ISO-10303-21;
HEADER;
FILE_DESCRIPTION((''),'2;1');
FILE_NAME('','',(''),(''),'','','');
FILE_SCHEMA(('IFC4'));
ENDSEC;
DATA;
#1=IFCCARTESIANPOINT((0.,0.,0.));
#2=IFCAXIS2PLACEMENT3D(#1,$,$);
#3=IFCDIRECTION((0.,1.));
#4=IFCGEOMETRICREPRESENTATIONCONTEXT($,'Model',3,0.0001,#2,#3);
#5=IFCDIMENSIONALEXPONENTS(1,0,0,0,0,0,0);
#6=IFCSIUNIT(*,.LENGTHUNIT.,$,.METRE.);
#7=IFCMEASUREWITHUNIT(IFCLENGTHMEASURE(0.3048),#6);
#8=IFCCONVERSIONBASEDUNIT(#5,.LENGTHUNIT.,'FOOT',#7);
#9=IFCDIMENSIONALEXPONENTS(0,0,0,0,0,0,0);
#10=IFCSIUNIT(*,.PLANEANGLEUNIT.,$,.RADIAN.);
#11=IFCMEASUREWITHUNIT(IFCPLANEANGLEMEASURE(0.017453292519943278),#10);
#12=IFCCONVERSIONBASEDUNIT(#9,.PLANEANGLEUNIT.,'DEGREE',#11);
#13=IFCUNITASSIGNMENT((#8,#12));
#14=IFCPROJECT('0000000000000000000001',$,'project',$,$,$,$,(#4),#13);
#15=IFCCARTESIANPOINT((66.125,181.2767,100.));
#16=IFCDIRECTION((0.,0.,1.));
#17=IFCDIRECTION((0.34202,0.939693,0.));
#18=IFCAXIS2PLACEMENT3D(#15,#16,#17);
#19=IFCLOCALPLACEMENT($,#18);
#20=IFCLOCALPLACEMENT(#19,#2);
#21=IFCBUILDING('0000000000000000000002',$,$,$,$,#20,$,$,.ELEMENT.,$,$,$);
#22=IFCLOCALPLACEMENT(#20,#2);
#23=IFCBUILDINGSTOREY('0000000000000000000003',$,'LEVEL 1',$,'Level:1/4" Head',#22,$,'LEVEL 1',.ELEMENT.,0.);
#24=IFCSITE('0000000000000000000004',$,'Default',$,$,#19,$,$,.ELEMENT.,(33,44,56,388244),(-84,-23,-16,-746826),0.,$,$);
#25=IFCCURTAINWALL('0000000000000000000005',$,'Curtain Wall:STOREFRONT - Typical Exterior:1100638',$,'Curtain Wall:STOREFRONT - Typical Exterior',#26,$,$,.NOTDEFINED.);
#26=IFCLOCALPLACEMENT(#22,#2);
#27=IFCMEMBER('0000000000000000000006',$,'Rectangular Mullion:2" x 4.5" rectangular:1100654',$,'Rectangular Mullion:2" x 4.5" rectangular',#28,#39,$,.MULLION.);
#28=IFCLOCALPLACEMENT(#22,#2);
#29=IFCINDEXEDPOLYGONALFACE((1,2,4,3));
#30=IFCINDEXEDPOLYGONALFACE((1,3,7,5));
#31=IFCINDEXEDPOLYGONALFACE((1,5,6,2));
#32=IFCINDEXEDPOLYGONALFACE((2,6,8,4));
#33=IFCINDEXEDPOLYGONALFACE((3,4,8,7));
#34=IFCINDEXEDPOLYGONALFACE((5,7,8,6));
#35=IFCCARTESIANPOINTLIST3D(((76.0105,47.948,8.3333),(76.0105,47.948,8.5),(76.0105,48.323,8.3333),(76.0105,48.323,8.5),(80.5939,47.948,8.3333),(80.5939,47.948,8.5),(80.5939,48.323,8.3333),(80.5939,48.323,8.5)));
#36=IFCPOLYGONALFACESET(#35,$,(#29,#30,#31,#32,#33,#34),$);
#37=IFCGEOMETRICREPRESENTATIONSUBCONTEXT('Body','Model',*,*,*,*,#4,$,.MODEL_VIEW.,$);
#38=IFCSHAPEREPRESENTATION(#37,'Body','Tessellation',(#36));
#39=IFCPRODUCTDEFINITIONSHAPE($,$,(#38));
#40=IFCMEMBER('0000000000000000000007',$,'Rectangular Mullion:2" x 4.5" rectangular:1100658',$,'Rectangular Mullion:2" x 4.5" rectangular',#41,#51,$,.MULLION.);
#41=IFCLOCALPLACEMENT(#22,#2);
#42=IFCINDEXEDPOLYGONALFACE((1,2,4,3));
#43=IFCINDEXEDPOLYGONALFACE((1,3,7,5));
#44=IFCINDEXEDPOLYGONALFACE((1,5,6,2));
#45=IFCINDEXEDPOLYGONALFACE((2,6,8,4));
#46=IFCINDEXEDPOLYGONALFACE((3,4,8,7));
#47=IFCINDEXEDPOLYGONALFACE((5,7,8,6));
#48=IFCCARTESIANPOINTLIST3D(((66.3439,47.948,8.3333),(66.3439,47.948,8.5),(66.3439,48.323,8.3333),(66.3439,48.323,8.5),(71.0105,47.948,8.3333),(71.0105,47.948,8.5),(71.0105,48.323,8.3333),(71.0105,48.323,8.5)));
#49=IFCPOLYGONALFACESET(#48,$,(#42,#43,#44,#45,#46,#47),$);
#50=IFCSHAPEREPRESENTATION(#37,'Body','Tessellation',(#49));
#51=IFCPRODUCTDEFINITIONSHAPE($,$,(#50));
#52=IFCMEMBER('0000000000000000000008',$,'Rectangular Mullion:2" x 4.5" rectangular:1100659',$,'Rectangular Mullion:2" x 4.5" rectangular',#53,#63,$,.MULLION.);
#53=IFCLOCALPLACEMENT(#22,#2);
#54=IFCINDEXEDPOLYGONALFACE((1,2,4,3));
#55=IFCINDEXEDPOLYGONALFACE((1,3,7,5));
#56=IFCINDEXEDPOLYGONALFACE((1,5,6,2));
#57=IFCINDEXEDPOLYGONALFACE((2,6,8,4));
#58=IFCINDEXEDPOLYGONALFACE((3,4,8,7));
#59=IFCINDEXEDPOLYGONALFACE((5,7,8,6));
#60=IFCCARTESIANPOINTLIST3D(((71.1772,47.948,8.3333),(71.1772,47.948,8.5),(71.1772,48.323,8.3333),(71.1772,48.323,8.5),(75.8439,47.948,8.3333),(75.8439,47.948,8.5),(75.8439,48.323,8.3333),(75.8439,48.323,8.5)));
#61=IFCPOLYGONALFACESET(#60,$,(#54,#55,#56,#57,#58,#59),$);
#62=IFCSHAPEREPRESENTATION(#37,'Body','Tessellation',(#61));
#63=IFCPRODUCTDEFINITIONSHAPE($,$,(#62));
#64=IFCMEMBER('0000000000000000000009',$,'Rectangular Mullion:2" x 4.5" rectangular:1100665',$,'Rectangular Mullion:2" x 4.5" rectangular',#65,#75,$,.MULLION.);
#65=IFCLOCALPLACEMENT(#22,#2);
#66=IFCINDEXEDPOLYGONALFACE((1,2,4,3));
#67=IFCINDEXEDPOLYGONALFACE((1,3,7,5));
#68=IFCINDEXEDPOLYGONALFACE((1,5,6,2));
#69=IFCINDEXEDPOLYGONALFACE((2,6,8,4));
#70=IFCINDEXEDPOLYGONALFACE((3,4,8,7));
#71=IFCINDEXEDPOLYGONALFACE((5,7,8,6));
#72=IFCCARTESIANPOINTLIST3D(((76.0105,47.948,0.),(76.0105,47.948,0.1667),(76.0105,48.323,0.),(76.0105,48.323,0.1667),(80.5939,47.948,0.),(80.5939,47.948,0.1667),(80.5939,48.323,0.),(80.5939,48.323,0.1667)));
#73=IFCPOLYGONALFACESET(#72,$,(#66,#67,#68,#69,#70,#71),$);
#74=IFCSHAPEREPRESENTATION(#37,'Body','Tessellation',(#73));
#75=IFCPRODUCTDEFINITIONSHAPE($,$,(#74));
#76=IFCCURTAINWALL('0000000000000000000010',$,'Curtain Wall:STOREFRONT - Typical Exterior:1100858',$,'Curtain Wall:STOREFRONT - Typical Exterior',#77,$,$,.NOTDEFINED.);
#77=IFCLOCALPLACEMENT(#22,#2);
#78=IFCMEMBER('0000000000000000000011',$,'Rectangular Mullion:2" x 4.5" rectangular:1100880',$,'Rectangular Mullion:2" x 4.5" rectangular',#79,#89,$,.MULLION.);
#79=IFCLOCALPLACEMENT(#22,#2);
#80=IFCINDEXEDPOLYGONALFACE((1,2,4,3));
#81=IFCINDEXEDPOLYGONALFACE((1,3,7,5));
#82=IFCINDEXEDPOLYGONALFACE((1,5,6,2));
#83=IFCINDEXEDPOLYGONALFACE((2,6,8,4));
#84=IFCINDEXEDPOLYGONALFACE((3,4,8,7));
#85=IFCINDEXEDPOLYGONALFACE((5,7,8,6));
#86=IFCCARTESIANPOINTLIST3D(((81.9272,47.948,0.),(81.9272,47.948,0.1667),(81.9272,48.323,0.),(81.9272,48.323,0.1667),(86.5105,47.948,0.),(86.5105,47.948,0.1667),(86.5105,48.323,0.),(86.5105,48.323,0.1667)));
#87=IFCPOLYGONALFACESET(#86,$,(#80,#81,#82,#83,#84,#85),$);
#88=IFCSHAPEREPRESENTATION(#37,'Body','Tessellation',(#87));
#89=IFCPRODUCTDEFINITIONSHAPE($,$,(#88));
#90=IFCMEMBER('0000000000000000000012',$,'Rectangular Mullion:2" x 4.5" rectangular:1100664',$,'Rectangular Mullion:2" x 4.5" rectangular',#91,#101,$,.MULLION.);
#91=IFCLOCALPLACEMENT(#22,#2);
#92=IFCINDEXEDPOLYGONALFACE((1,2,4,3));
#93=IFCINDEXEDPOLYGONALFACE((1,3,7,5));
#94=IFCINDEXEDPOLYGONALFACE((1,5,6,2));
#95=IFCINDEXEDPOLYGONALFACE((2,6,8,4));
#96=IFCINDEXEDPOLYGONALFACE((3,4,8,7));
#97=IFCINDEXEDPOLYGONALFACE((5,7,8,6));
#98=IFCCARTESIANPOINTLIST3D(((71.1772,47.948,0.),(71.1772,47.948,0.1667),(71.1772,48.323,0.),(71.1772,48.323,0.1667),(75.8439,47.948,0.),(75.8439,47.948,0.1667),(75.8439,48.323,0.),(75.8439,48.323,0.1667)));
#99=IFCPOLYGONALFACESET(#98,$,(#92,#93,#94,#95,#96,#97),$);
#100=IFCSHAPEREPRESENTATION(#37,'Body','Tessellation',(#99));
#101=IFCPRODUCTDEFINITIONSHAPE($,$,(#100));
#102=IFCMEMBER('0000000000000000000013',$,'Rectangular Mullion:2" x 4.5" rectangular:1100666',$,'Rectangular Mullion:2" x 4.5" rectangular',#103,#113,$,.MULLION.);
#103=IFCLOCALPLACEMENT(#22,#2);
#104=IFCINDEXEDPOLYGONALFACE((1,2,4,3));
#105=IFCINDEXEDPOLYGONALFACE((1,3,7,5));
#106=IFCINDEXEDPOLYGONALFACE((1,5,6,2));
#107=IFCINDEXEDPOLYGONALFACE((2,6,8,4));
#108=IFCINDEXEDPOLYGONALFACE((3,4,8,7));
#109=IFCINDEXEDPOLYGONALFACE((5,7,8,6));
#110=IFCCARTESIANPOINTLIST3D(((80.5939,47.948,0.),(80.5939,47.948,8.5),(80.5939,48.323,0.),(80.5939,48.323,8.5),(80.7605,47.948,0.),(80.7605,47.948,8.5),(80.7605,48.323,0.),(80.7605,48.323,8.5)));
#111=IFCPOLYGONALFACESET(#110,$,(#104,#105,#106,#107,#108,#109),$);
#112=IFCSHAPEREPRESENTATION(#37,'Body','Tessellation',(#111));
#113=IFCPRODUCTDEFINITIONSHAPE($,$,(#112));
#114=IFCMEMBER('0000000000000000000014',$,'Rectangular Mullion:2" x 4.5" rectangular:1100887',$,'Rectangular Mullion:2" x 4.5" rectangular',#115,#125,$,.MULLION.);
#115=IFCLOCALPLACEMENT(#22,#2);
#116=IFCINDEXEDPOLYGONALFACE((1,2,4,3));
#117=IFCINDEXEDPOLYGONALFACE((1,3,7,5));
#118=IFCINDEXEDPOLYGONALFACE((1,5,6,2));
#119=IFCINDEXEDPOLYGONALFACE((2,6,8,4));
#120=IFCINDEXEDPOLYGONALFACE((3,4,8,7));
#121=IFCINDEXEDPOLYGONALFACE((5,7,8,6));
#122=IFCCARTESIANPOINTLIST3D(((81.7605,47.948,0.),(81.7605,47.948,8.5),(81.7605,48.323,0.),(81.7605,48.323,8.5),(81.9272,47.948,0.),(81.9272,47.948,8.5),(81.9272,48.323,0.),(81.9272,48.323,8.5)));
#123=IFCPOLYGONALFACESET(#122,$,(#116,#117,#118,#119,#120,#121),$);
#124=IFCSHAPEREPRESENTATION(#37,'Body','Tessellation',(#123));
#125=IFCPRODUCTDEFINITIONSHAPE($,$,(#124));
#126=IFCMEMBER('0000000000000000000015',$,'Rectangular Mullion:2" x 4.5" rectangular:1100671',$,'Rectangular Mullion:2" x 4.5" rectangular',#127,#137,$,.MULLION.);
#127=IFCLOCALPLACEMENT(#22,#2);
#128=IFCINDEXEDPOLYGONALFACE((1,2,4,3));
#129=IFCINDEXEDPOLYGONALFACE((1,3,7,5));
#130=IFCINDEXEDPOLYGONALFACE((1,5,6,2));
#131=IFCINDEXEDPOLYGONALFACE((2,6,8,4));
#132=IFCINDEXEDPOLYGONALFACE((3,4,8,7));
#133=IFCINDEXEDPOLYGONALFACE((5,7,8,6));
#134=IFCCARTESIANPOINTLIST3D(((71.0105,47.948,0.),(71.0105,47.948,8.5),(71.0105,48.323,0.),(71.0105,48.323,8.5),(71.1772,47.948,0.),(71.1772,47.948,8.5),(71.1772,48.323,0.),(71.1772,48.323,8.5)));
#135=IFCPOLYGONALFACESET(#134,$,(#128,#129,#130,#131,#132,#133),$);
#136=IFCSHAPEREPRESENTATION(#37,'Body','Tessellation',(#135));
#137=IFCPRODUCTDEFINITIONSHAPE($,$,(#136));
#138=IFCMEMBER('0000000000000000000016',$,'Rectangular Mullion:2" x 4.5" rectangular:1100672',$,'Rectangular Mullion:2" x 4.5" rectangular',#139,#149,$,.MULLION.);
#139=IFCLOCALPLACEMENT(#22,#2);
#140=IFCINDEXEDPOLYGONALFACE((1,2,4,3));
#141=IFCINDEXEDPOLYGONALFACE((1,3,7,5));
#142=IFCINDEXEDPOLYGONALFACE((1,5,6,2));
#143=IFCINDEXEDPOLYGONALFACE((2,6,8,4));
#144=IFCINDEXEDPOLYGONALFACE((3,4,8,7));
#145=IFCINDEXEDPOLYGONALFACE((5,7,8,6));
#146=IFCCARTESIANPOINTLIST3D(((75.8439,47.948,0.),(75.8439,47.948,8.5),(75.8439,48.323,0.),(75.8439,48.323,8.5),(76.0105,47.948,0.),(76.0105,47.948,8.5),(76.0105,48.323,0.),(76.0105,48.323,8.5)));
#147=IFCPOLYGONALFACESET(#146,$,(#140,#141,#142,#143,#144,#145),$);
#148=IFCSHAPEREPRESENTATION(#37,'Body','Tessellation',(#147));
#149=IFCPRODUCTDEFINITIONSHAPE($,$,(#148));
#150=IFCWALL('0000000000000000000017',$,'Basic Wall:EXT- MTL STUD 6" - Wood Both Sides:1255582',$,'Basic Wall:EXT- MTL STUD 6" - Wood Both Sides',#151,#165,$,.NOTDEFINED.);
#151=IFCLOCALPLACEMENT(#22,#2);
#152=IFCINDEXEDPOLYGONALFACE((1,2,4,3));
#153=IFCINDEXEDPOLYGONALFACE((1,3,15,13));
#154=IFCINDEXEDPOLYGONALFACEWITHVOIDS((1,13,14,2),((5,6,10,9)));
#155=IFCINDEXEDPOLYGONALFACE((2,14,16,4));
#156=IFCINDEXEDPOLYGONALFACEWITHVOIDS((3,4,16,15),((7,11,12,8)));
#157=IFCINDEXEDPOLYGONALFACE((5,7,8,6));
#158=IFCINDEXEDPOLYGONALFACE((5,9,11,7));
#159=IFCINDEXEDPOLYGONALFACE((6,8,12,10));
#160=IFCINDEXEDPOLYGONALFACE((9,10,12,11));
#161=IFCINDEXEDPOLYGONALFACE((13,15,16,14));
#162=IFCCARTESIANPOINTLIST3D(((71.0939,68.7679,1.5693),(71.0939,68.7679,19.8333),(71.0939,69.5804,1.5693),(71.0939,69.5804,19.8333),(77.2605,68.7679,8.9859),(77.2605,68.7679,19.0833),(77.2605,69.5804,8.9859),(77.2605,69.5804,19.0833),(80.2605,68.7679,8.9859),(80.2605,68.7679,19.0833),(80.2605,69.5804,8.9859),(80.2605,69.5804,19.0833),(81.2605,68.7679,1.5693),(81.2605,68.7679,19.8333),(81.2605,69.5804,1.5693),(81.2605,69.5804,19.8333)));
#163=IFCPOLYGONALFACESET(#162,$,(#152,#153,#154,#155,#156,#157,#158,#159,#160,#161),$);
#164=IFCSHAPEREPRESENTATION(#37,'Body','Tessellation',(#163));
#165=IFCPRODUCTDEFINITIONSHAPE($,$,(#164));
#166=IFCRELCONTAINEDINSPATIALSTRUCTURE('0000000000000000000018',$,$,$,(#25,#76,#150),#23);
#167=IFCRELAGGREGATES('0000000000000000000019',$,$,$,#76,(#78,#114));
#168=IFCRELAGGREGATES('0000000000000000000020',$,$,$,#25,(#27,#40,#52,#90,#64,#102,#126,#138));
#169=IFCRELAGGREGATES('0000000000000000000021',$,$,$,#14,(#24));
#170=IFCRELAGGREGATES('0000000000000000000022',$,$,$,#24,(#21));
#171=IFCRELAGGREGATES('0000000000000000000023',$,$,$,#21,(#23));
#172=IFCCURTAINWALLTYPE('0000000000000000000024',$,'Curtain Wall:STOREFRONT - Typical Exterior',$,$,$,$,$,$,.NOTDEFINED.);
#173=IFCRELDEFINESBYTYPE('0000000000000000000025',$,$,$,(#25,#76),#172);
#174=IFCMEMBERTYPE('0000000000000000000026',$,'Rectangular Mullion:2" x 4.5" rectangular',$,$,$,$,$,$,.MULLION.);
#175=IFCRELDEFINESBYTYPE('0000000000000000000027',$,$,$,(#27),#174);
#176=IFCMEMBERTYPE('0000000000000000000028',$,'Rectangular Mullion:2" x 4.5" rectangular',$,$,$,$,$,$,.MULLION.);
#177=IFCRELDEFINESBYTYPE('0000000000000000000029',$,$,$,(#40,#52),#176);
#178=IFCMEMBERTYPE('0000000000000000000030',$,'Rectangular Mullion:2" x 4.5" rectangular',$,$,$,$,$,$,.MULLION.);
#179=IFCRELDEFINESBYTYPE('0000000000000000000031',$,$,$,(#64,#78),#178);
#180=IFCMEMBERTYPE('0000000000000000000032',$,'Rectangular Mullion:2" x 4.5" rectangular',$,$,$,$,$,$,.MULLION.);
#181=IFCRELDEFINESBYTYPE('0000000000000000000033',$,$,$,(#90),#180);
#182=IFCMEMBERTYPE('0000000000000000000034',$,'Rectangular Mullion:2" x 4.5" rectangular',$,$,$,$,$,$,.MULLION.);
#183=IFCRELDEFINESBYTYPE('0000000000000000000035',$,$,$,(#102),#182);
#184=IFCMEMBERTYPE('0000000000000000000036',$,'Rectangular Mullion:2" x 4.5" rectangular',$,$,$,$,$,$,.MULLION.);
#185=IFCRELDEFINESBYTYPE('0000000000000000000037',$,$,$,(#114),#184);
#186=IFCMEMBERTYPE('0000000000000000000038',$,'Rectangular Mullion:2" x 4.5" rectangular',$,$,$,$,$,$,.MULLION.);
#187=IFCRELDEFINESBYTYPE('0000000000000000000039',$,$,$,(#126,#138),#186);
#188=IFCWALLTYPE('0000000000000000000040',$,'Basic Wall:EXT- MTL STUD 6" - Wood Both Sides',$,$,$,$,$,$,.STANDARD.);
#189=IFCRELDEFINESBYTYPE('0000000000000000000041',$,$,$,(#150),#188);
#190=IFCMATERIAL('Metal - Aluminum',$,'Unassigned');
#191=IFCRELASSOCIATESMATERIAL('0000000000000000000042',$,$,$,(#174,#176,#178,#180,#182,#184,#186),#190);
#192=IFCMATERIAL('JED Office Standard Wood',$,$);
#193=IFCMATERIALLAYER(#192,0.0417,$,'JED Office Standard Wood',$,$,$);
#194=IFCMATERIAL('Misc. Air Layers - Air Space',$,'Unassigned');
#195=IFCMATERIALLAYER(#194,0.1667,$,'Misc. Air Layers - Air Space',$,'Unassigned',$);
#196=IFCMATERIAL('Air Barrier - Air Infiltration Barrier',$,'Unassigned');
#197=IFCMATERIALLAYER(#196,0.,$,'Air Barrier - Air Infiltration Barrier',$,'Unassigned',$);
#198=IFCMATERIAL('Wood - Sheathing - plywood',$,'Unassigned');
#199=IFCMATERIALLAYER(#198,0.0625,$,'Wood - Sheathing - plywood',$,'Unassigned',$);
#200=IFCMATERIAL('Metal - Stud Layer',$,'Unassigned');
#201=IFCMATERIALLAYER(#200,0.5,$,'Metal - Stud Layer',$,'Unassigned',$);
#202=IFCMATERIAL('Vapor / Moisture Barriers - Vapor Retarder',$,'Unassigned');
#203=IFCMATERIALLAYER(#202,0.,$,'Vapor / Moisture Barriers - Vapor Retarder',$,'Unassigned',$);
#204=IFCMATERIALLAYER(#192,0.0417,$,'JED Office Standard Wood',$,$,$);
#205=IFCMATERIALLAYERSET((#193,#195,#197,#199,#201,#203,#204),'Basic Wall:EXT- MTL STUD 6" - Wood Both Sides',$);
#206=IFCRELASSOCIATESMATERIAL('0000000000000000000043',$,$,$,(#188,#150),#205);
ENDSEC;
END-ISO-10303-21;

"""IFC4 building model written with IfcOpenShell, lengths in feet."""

from ifc_helpers import new_model, entity, si_unit, converted_unit, direction, frame, frame_2d, origin, origin_2d_with_axis, place, context, subcontext, project, spatial, rectangle, extrude, source, transform, mapped, material, layer, layer_set, layer_usage, material_profile, profile_set, type_object, type_shapes, element, aggregate, save


model = new_model("IFC4")

# Units and contexts
model_context = context("Model", 3, precision=0.0001, world=origin(), true_north=direction((0.0, 1.0)))
body_context = subcontext(model_context, "Body", "Model", "MODEL_VIEW")
ifc_project = project(units=[converted_unit("LENGTHUNIT", "FOOT", entity("IfcLengthMeasure", 0.3048), si_unit("LENGTHUNIT", "METRE"), dimensions=[1, 0, 0, 0, 0, 0, 0]), converted_unit("PLANEANGLEUNIT", "DEGREE", entity("IfcPlaneAngleMeasure", 0.017453292519943278), si_unit("PLANEANGLEUNIT", "RADIAN"), dimensions=[0, 0, 0, 0, 0, 0, 0])], contexts=[model_context])

# Site, building, storey
site_placement = place(None, frame((66.125, 181.2767, 100.0), z_axis=(0.0, 0.0, 1.0), x_axis=(0.34202, 0.939693, 0.0)))
site = spatial("IfcSite", under=ifc_project, at=site_placement, Name="Default", CompositionType="ELEMENT", RefLatitude=(33, 44, 56, 388244), RefLongitude=(-84, -23, -16, -746826), RefElevation=0.0)
building_placement = place(site_placement, origin())
building = spatial("IfcBuilding", under=site, at=building_placement, CompositionType="ELEMENT")
storey_placement = place(building_placement, origin())
storey = spatial("IfcBuildingStorey", under=building, at=storey_placement, Name="LEVEL 1", ObjectType="Level:1/4\" Head", LongName="LEVEL 1", CompositionType="ELEMENT", Elevation=0.0)

# Curtain wall, members
curtain_wall_type = type_object("IfcCurtainWallType", Name="Curtain Wall:STOREFRONT - Typical Exterior", PredefinedType="NOTDEFINED")
curtain_wall_1_placement = place(storey_placement, origin())
curtain_wall_1 = element("IfcCurtainWall", 1, at=curtain_wall_1_placement, inside=storey, type_object=curtain_wall_type, Name="Curtain Wall:STOREFRONT - Typical Exterior:1100638", ObjectType="Curtain Wall:STOREFRONT - Typical Exterior", PredefinedType="NOTDEFINED")
ifc_material_1 = material(Name="Metal - Aluminum", Category="Unassigned")
ifc_material_profile = material_profile(ifc_material_1, rectangle(XDim=0.1667, YDim=0.375, at=origin_2d_with_axis()), Name="2\" x 4.5\" rectangular")
ifc_profile_set = profile_set([ifc_material_profile], Name="2\" x 4.5\" rectangular")
member_type_1 = type_object("IfcMemberType", Name="Rectangular Mullion:2\" x 4.5\" rectangular", PredefinedType="MULLION", material=ifc_profile_set)
shared_shape_1 = source(origin(), body_context, "Body", "SweptSolid", [
    extrude(rectangle(XDim=0.1667, YDim=0.375, at=origin_2d_with_axis()), frame((-0.0833, 0.0, -4.5833), z_axis=(0.0, 0.0, 1.0), x_axis=(-1.0, 0.0, 0.0)), (0.0, 0.0, 1.0), 4.5833),
])
type_shapes(member_type_1, [shared_shape_1])
member_1_placement = place(curtain_wall_1_placement, frame((80.5939, 48.1355, 8.5), z_axis=(1.0, 0.0, 0.0), x_axis=(0.0, 0.0, 1.0)))
member_1 = element("IfcMember", 2, at=member_1_placement, type_object=member_type_1, Name="Rectangular Mullion:2\" x 4.5\" rectangular:1100654", ObjectType="Rectangular Mullion:2\" x 4.5\" rectangular", PredefinedType="MULLION", context=body_context, shape_type="MappedRepresentation", body=[
    mapped(shared_shape_1, transform((0.0, 0.0, 0.0), scale=1.0)),
])
member_type_2 = type_object("IfcMemberType", Name="Rectangular Mullion:2\" x 4.5\" rectangular", PredefinedType="MULLION", material=ifc_profile_set)
shared_shape_2 = source(origin(), body_context, "Body", "SweptSolid", [
    extrude(rectangle(XDim=0.1667, YDim=0.375, at=origin_2d_with_axis()), frame((-0.0833, 0.0, -4.6667), z_axis=(0.0, 0.0, 1.0), x_axis=(-1.0, 0.0, 0.0)), (0.0, 0.0, 1.0), 4.6667),
])
type_shapes(member_type_2, [shared_shape_2])
member_2_placement = place(curtain_wall_1_placement, frame((71.0105, 48.1355, 8.5), z_axis=(1.0, 0.0, 0.0), x_axis=(0.0, 0.0, 1.0)))
member_2 = element("IfcMember", 3, at=member_2_placement, type_object=member_type_2, Name="Rectangular Mullion:2\" x 4.5\" rectangular:1100658", ObjectType="Rectangular Mullion:2\" x 4.5\" rectangular", PredefinedType="MULLION", context=body_context, shape_type="MappedRepresentation", body=[
    mapped(shared_shape_2, transform((0.0, 0.0, 0.0), scale=1.0)),
])
member_3_placement = place(curtain_wall_1_placement, frame((75.8439, 48.1355, 8.5), z_axis=(1.0, 0.0, 0.0), x_axis=(0.0, 0.0, 1.0)))
member_3 = element("IfcMember", 4, at=member_3_placement, type_object=member_type_2, Name="Rectangular Mullion:2\" x 4.5\" rectangular:1100659", ObjectType="Rectangular Mullion:2\" x 4.5\" rectangular", PredefinedType="MULLION", context=body_context, shape_type="MappedRepresentation", body=[
    mapped(shared_shape_2, transform((0.0, 0.0, 0.0), scale=1.0)),
])
member_type_3 = type_object("IfcMemberType", Name="Rectangular Mullion:2\" x 4.5\" rectangular", PredefinedType="MULLION", material=ifc_profile_set)
shared_shape_3 = source(origin(), body_context, "Body", "SweptSolid", [
    extrude(rectangle(XDim=0.1667, YDim=0.375, at=origin_2d_with_axis()), frame((-0.0833, 0.0, -4.5833), z_axis=(0.0, 0.0, 1.0), x_axis=(-1.0, 0.0, 0.0)), (0.0, 0.0, 1.0), 4.5833),
])
type_shapes(member_type_3, [shared_shape_3])
member_4_placement = place(curtain_wall_1_placement, frame((76.0105, 48.1355, 0.0), z_axis=(-1.0, 0.0, 0.0), x_axis=(0.0, 0.0, -1.0)))
member_4 = element("IfcMember", 5, at=member_4_placement, type_object=member_type_3, Name="Rectangular Mullion:2\" x 4.5\" rectangular:1100665", ObjectType="Rectangular Mullion:2\" x 4.5\" rectangular", PredefinedType="MULLION", context=body_context, shape_type="MappedRepresentation", body=[
    mapped(shared_shape_3, transform((0.0, 0.0, 0.0), scale=1.0)),
])

# Curtain wall, member
curtain_wall_2_placement = place(storey_placement, origin())
curtain_wall_2 = element("IfcCurtainWall", 6, at=curtain_wall_2_placement, inside=storey, type_object=curtain_wall_type, Name="Curtain Wall:STOREFRONT - Typical Exterior:1100858", ObjectType="Curtain Wall:STOREFRONT - Typical Exterior", PredefinedType="NOTDEFINED")
member_5_placement = place(curtain_wall_2_placement, frame((81.9272, 48.1355, 0.0), z_axis=(-1.0, 0.0, 0.0), x_axis=(0.0, 0.0, -1.0)))
member_5 = element("IfcMember", 7, at=member_5_placement, type_object=member_type_3, Name="Rectangular Mullion:2\" x 4.5\" rectangular:1100880", ObjectType="Rectangular Mullion:2\" x 4.5\" rectangular", PredefinedType="MULLION", context=body_context, shape_type="MappedRepresentation", body=[
    mapped(shared_shape_3, transform((0.0, 0.0, 0.0), scale=1.0)),
])

# Members
member_type_4 = type_object("IfcMemberType", Name="Rectangular Mullion:2\" x 4.5\" rectangular", PredefinedType="MULLION", material=ifc_profile_set)
shared_shape_4 = source(origin(), body_context, "Body", "SweptSolid", [
    extrude(rectangle(XDim=0.1667, YDim=0.375, at=origin_2d_with_axis()), frame((-0.0833, 0.0, -4.6667), z_axis=(0.0, 0.0, 1.0), x_axis=(-1.0, 0.0, 0.0)), (0.0, 0.0, 1.0), 4.6667),
])
type_shapes(member_type_4, [shared_shape_4])
member_6_placement = place(curtain_wall_1_placement, frame((71.1772, 48.1355, 0.0), z_axis=(-1.0, 0.0, 0.0), x_axis=(0.0, 0.0, -1.0)))
member_6 = element("IfcMember", 8, at=member_6_placement, type_object=member_type_4, Name="Rectangular Mullion:2\" x 4.5\" rectangular:1100664", ObjectType="Rectangular Mullion:2\" x 4.5\" rectangular", PredefinedType="MULLION", context=body_context, shape_type="MappedRepresentation", body=[
    mapped(shared_shape_4, transform((0.0, 0.0, 0.0), scale=1.0)),
])
member_type_5 = type_object("IfcMemberType", Name="Rectangular Mullion:2\" x 4.5\" rectangular", PredefinedType="MULLION", material=ifc_profile_set)
shared_shape_5 = source(origin(), body_context, "Body", "SweptSolid", [
    extrude(rectangle(XDim=0.1667, YDim=0.375, at=origin_2d_with_axis()), frame((-0.0833, 0.0, -8.5), z_axis=(0.0, 0.0, 1.0), x_axis=(-1.0, 0.0, 0.0)), (0.0, 0.0, 1.0), 8.5),
])
type_shapes(member_type_5, [shared_shape_5])
member_7_placement = place(curtain_wall_1_placement, frame((80.7605, 48.1355, 0.0), z_axis=(0.0, 0.0, -1.0), x_axis=(1.0, 0.0, 0.0)))
member_7 = element("IfcMember", 9, at=member_7_placement, type_object=member_type_5, Name="Rectangular Mullion:2\" x 4.5\" rectangular:1100666", ObjectType="Rectangular Mullion:2\" x 4.5\" rectangular", PredefinedType="MULLION", context=body_context, shape_type="MappedRepresentation", body=[
    mapped(shared_shape_5, transform((0.0, 0.0, 0.0), scale=1.0)),
])
member_type_6 = type_object("IfcMemberType", Name="Rectangular Mullion:2\" x 4.5\" rectangular", PredefinedType="MULLION", material=ifc_profile_set)
shared_shape_6 = source(origin(), body_context, "Body", "SweptSolid", [
    extrude(rectangle(XDim=0.1667, YDim=0.375, at=origin_2d_with_axis()), frame((-0.0833, 0.0, -8.5), z_axis=(0.0, 0.0, 1.0), x_axis=(-1.0, 0.0, 0.0)), (0.0, 0.0, 1.0), 8.5),
])
type_shapes(member_type_6, [shared_shape_6])
member_8_placement = place(curtain_wall_2_placement, frame((81.7605, 48.1355, 8.5), z_axis=(0.0, 0.0, 1.0), x_axis=(-1.0, 0.0, 0.0)))
member_8 = element("IfcMember", 10, at=member_8_placement, type_object=member_type_6, Name="Rectangular Mullion:2\" x 4.5\" rectangular:1100887", ObjectType="Rectangular Mullion:2\" x 4.5\" rectangular", PredefinedType="MULLION", context=body_context, shape_type="MappedRepresentation", body=[
    mapped(shared_shape_6, transform((0.0, 0.0, 0.0), scale=1.0)),
])
aggregate(curtain_wall_2, [member_5, member_8])
member_type_7 = type_object("IfcMemberType", Name="Rectangular Mullion:2\" x 4.5\" rectangular", PredefinedType="MULLION", material=ifc_profile_set)
shared_shape_7 = source(origin(), body_context, "Body", "SweptSolid", [
    extrude(rectangle(XDim=0.1667, YDim=0.375, at=origin_2d_with_axis()), frame((0.0, 0.0, -8.5), z_axis=(0.0, 0.0, 1.0), x_axis=(-1.0, 0.0, 0.0)), (0.0, 0.0, 1.0), 8.5),
])
type_shapes(member_type_7, [shared_shape_7])
member_9_placement = place(curtain_wall_1_placement, frame((71.0939, 48.1355, 0.0), z_axis=(0.0, 0.0, -1.0), x_axis=(1.0, 0.0, 0.0)))
member_9 = element("IfcMember", 11, at=member_9_placement, type_object=member_type_7, Name="Rectangular Mullion:2\" x 4.5\" rectangular:1100671", ObjectType="Rectangular Mullion:2\" x 4.5\" rectangular", PredefinedType="MULLION", context=body_context, shape_type="MappedRepresentation", body=[
    mapped(shared_shape_7, transform((0.0, 0.0, 0.0), scale=1.0)),
])
member_10_placement = place(curtain_wall_1_placement, frame((75.9272, 48.1355, 0.0), z_axis=(0.0, 0.0, -1.0), x_axis=(1.0, 0.0, 0.0)))
member_10 = element("IfcMember", 12, at=member_10_placement, type_object=member_type_7, Name="Rectangular Mullion:2\" x 4.5\" rectangular:1100672", ObjectType="Rectangular Mullion:2\" x 4.5\" rectangular", PredefinedType="MULLION", context=body_context, shape_type="MappedRepresentation", body=[
    mapped(shared_shape_7, transform((0.0, 0.0, 0.0), scale=1.0)),
])

aggregate(curtain_wall_1, [member_1, member_2, member_3, member_6, member_4, member_7, member_9, member_10])

# Wall, opening
ifc_material_2 = material(Name="JED Office Standard Wood")
ifc_layer_1 = layer(ifc_material_2, 0.0417, Name="JED Office Standard Wood")
ifc_material_3 = material(Name="Misc. Air Layers - Air Space", Category="Unassigned")
ifc_layer_2 = layer(ifc_material_3, 0.1667, Name="Misc. Air Layers - Air Space", Category="Unassigned")
ifc_material_4 = material(Name="Air Barrier - Air Infiltration Barrier", Category="Unassigned")
ifc_layer_3 = layer(ifc_material_4, 0.0, Name="Air Barrier - Air Infiltration Barrier", Category="Unassigned")
ifc_material_5 = material(Name="Wood - Sheathing - plywood", Category="Unassigned")
ifc_layer_4 = layer(ifc_material_5, 0.0625, Name="Wood - Sheathing - plywood", Category="Unassigned")
ifc_material_6 = material(Name="Metal - Stud Layer", Category="Unassigned")
ifc_layer_5 = layer(ifc_material_6, 0.5, Name="Metal - Stud Layer", Category="Unassigned")
ifc_material_7 = material(Name="Vapor / Moisture Barriers - Vapor Retarder", Category="Unassigned")
ifc_layer_6 = layer(ifc_material_7, 0.0, Name="Vapor / Moisture Barriers - Vapor Retarder", Category="Unassigned")
ifc_layer_7 = layer(ifc_material_2, 0.0417, Name="JED Office Standard Wood")
ifc_layer_set_1 = layer_set([ifc_layer_1, ifc_layer_2, ifc_layer_3, ifc_layer_4, ifc_layer_5, ifc_layer_6, ifc_layer_7], Name="Basic Wall:EXT- MTL STUD 6\" - Wood Both Sides")
ifc_layer_usage_1 = layer_usage(ifc_layer_set_1, "AXIS2", "NEGATIVE", 0.4062)
wall_type_1 = type_object("IfcWallType", Name="Basic Wall:EXT- MTL STUD 6\" - Wood Both Sides", PredefinedType="STANDARD", material=ifc_layer_set_1)
wall_1_placement = place(storey_placement, frame((71.0939, 69.1742, 1.5693)))
wall_1 = element("IfcWall", 13, at=wall_1_placement, inside=storey, type_object=wall_type_1, material=ifc_layer_usage_1, Name="Basic Wall:EXT- MTL STUD 6\" - Wood Both Sides:1255582", ObjectType="Basic Wall:EXT- MTL STUD 6\" - Wood Both Sides", PredefinedType="NOTDEFINED", context=body_context, shape_type="SweptSolid", body=[
    extrude(rectangle(XDim=10.1667, YDim=0.8125, at=frame_2d((5.0833, 0.0), x_axis=(-1.0, 0.0))), origin(), (0.0, 0.0, 1.0), 18.2641),
])
opening_1_placement = place(wall_1_placement, origin())
element("IfcOpeningElement", 14, at=opening_1_placement, cuts=wall_1, PredefinedType="OPENING", context=body_context, shape_type="SweptSolid", body=[
    extrude(rectangle(XDim=10.0974, YDim=3.0, at=origin_2d_with_axis()), frame((7.6667, 0.4062, 12.4654), z_axis=(0.0, -1.0, 0.0), x_axis=(0.0, 0.0, -1.0)), (0.0, 0.0, 1.0), 0.8125),
])

save(model, "model.ifc")
